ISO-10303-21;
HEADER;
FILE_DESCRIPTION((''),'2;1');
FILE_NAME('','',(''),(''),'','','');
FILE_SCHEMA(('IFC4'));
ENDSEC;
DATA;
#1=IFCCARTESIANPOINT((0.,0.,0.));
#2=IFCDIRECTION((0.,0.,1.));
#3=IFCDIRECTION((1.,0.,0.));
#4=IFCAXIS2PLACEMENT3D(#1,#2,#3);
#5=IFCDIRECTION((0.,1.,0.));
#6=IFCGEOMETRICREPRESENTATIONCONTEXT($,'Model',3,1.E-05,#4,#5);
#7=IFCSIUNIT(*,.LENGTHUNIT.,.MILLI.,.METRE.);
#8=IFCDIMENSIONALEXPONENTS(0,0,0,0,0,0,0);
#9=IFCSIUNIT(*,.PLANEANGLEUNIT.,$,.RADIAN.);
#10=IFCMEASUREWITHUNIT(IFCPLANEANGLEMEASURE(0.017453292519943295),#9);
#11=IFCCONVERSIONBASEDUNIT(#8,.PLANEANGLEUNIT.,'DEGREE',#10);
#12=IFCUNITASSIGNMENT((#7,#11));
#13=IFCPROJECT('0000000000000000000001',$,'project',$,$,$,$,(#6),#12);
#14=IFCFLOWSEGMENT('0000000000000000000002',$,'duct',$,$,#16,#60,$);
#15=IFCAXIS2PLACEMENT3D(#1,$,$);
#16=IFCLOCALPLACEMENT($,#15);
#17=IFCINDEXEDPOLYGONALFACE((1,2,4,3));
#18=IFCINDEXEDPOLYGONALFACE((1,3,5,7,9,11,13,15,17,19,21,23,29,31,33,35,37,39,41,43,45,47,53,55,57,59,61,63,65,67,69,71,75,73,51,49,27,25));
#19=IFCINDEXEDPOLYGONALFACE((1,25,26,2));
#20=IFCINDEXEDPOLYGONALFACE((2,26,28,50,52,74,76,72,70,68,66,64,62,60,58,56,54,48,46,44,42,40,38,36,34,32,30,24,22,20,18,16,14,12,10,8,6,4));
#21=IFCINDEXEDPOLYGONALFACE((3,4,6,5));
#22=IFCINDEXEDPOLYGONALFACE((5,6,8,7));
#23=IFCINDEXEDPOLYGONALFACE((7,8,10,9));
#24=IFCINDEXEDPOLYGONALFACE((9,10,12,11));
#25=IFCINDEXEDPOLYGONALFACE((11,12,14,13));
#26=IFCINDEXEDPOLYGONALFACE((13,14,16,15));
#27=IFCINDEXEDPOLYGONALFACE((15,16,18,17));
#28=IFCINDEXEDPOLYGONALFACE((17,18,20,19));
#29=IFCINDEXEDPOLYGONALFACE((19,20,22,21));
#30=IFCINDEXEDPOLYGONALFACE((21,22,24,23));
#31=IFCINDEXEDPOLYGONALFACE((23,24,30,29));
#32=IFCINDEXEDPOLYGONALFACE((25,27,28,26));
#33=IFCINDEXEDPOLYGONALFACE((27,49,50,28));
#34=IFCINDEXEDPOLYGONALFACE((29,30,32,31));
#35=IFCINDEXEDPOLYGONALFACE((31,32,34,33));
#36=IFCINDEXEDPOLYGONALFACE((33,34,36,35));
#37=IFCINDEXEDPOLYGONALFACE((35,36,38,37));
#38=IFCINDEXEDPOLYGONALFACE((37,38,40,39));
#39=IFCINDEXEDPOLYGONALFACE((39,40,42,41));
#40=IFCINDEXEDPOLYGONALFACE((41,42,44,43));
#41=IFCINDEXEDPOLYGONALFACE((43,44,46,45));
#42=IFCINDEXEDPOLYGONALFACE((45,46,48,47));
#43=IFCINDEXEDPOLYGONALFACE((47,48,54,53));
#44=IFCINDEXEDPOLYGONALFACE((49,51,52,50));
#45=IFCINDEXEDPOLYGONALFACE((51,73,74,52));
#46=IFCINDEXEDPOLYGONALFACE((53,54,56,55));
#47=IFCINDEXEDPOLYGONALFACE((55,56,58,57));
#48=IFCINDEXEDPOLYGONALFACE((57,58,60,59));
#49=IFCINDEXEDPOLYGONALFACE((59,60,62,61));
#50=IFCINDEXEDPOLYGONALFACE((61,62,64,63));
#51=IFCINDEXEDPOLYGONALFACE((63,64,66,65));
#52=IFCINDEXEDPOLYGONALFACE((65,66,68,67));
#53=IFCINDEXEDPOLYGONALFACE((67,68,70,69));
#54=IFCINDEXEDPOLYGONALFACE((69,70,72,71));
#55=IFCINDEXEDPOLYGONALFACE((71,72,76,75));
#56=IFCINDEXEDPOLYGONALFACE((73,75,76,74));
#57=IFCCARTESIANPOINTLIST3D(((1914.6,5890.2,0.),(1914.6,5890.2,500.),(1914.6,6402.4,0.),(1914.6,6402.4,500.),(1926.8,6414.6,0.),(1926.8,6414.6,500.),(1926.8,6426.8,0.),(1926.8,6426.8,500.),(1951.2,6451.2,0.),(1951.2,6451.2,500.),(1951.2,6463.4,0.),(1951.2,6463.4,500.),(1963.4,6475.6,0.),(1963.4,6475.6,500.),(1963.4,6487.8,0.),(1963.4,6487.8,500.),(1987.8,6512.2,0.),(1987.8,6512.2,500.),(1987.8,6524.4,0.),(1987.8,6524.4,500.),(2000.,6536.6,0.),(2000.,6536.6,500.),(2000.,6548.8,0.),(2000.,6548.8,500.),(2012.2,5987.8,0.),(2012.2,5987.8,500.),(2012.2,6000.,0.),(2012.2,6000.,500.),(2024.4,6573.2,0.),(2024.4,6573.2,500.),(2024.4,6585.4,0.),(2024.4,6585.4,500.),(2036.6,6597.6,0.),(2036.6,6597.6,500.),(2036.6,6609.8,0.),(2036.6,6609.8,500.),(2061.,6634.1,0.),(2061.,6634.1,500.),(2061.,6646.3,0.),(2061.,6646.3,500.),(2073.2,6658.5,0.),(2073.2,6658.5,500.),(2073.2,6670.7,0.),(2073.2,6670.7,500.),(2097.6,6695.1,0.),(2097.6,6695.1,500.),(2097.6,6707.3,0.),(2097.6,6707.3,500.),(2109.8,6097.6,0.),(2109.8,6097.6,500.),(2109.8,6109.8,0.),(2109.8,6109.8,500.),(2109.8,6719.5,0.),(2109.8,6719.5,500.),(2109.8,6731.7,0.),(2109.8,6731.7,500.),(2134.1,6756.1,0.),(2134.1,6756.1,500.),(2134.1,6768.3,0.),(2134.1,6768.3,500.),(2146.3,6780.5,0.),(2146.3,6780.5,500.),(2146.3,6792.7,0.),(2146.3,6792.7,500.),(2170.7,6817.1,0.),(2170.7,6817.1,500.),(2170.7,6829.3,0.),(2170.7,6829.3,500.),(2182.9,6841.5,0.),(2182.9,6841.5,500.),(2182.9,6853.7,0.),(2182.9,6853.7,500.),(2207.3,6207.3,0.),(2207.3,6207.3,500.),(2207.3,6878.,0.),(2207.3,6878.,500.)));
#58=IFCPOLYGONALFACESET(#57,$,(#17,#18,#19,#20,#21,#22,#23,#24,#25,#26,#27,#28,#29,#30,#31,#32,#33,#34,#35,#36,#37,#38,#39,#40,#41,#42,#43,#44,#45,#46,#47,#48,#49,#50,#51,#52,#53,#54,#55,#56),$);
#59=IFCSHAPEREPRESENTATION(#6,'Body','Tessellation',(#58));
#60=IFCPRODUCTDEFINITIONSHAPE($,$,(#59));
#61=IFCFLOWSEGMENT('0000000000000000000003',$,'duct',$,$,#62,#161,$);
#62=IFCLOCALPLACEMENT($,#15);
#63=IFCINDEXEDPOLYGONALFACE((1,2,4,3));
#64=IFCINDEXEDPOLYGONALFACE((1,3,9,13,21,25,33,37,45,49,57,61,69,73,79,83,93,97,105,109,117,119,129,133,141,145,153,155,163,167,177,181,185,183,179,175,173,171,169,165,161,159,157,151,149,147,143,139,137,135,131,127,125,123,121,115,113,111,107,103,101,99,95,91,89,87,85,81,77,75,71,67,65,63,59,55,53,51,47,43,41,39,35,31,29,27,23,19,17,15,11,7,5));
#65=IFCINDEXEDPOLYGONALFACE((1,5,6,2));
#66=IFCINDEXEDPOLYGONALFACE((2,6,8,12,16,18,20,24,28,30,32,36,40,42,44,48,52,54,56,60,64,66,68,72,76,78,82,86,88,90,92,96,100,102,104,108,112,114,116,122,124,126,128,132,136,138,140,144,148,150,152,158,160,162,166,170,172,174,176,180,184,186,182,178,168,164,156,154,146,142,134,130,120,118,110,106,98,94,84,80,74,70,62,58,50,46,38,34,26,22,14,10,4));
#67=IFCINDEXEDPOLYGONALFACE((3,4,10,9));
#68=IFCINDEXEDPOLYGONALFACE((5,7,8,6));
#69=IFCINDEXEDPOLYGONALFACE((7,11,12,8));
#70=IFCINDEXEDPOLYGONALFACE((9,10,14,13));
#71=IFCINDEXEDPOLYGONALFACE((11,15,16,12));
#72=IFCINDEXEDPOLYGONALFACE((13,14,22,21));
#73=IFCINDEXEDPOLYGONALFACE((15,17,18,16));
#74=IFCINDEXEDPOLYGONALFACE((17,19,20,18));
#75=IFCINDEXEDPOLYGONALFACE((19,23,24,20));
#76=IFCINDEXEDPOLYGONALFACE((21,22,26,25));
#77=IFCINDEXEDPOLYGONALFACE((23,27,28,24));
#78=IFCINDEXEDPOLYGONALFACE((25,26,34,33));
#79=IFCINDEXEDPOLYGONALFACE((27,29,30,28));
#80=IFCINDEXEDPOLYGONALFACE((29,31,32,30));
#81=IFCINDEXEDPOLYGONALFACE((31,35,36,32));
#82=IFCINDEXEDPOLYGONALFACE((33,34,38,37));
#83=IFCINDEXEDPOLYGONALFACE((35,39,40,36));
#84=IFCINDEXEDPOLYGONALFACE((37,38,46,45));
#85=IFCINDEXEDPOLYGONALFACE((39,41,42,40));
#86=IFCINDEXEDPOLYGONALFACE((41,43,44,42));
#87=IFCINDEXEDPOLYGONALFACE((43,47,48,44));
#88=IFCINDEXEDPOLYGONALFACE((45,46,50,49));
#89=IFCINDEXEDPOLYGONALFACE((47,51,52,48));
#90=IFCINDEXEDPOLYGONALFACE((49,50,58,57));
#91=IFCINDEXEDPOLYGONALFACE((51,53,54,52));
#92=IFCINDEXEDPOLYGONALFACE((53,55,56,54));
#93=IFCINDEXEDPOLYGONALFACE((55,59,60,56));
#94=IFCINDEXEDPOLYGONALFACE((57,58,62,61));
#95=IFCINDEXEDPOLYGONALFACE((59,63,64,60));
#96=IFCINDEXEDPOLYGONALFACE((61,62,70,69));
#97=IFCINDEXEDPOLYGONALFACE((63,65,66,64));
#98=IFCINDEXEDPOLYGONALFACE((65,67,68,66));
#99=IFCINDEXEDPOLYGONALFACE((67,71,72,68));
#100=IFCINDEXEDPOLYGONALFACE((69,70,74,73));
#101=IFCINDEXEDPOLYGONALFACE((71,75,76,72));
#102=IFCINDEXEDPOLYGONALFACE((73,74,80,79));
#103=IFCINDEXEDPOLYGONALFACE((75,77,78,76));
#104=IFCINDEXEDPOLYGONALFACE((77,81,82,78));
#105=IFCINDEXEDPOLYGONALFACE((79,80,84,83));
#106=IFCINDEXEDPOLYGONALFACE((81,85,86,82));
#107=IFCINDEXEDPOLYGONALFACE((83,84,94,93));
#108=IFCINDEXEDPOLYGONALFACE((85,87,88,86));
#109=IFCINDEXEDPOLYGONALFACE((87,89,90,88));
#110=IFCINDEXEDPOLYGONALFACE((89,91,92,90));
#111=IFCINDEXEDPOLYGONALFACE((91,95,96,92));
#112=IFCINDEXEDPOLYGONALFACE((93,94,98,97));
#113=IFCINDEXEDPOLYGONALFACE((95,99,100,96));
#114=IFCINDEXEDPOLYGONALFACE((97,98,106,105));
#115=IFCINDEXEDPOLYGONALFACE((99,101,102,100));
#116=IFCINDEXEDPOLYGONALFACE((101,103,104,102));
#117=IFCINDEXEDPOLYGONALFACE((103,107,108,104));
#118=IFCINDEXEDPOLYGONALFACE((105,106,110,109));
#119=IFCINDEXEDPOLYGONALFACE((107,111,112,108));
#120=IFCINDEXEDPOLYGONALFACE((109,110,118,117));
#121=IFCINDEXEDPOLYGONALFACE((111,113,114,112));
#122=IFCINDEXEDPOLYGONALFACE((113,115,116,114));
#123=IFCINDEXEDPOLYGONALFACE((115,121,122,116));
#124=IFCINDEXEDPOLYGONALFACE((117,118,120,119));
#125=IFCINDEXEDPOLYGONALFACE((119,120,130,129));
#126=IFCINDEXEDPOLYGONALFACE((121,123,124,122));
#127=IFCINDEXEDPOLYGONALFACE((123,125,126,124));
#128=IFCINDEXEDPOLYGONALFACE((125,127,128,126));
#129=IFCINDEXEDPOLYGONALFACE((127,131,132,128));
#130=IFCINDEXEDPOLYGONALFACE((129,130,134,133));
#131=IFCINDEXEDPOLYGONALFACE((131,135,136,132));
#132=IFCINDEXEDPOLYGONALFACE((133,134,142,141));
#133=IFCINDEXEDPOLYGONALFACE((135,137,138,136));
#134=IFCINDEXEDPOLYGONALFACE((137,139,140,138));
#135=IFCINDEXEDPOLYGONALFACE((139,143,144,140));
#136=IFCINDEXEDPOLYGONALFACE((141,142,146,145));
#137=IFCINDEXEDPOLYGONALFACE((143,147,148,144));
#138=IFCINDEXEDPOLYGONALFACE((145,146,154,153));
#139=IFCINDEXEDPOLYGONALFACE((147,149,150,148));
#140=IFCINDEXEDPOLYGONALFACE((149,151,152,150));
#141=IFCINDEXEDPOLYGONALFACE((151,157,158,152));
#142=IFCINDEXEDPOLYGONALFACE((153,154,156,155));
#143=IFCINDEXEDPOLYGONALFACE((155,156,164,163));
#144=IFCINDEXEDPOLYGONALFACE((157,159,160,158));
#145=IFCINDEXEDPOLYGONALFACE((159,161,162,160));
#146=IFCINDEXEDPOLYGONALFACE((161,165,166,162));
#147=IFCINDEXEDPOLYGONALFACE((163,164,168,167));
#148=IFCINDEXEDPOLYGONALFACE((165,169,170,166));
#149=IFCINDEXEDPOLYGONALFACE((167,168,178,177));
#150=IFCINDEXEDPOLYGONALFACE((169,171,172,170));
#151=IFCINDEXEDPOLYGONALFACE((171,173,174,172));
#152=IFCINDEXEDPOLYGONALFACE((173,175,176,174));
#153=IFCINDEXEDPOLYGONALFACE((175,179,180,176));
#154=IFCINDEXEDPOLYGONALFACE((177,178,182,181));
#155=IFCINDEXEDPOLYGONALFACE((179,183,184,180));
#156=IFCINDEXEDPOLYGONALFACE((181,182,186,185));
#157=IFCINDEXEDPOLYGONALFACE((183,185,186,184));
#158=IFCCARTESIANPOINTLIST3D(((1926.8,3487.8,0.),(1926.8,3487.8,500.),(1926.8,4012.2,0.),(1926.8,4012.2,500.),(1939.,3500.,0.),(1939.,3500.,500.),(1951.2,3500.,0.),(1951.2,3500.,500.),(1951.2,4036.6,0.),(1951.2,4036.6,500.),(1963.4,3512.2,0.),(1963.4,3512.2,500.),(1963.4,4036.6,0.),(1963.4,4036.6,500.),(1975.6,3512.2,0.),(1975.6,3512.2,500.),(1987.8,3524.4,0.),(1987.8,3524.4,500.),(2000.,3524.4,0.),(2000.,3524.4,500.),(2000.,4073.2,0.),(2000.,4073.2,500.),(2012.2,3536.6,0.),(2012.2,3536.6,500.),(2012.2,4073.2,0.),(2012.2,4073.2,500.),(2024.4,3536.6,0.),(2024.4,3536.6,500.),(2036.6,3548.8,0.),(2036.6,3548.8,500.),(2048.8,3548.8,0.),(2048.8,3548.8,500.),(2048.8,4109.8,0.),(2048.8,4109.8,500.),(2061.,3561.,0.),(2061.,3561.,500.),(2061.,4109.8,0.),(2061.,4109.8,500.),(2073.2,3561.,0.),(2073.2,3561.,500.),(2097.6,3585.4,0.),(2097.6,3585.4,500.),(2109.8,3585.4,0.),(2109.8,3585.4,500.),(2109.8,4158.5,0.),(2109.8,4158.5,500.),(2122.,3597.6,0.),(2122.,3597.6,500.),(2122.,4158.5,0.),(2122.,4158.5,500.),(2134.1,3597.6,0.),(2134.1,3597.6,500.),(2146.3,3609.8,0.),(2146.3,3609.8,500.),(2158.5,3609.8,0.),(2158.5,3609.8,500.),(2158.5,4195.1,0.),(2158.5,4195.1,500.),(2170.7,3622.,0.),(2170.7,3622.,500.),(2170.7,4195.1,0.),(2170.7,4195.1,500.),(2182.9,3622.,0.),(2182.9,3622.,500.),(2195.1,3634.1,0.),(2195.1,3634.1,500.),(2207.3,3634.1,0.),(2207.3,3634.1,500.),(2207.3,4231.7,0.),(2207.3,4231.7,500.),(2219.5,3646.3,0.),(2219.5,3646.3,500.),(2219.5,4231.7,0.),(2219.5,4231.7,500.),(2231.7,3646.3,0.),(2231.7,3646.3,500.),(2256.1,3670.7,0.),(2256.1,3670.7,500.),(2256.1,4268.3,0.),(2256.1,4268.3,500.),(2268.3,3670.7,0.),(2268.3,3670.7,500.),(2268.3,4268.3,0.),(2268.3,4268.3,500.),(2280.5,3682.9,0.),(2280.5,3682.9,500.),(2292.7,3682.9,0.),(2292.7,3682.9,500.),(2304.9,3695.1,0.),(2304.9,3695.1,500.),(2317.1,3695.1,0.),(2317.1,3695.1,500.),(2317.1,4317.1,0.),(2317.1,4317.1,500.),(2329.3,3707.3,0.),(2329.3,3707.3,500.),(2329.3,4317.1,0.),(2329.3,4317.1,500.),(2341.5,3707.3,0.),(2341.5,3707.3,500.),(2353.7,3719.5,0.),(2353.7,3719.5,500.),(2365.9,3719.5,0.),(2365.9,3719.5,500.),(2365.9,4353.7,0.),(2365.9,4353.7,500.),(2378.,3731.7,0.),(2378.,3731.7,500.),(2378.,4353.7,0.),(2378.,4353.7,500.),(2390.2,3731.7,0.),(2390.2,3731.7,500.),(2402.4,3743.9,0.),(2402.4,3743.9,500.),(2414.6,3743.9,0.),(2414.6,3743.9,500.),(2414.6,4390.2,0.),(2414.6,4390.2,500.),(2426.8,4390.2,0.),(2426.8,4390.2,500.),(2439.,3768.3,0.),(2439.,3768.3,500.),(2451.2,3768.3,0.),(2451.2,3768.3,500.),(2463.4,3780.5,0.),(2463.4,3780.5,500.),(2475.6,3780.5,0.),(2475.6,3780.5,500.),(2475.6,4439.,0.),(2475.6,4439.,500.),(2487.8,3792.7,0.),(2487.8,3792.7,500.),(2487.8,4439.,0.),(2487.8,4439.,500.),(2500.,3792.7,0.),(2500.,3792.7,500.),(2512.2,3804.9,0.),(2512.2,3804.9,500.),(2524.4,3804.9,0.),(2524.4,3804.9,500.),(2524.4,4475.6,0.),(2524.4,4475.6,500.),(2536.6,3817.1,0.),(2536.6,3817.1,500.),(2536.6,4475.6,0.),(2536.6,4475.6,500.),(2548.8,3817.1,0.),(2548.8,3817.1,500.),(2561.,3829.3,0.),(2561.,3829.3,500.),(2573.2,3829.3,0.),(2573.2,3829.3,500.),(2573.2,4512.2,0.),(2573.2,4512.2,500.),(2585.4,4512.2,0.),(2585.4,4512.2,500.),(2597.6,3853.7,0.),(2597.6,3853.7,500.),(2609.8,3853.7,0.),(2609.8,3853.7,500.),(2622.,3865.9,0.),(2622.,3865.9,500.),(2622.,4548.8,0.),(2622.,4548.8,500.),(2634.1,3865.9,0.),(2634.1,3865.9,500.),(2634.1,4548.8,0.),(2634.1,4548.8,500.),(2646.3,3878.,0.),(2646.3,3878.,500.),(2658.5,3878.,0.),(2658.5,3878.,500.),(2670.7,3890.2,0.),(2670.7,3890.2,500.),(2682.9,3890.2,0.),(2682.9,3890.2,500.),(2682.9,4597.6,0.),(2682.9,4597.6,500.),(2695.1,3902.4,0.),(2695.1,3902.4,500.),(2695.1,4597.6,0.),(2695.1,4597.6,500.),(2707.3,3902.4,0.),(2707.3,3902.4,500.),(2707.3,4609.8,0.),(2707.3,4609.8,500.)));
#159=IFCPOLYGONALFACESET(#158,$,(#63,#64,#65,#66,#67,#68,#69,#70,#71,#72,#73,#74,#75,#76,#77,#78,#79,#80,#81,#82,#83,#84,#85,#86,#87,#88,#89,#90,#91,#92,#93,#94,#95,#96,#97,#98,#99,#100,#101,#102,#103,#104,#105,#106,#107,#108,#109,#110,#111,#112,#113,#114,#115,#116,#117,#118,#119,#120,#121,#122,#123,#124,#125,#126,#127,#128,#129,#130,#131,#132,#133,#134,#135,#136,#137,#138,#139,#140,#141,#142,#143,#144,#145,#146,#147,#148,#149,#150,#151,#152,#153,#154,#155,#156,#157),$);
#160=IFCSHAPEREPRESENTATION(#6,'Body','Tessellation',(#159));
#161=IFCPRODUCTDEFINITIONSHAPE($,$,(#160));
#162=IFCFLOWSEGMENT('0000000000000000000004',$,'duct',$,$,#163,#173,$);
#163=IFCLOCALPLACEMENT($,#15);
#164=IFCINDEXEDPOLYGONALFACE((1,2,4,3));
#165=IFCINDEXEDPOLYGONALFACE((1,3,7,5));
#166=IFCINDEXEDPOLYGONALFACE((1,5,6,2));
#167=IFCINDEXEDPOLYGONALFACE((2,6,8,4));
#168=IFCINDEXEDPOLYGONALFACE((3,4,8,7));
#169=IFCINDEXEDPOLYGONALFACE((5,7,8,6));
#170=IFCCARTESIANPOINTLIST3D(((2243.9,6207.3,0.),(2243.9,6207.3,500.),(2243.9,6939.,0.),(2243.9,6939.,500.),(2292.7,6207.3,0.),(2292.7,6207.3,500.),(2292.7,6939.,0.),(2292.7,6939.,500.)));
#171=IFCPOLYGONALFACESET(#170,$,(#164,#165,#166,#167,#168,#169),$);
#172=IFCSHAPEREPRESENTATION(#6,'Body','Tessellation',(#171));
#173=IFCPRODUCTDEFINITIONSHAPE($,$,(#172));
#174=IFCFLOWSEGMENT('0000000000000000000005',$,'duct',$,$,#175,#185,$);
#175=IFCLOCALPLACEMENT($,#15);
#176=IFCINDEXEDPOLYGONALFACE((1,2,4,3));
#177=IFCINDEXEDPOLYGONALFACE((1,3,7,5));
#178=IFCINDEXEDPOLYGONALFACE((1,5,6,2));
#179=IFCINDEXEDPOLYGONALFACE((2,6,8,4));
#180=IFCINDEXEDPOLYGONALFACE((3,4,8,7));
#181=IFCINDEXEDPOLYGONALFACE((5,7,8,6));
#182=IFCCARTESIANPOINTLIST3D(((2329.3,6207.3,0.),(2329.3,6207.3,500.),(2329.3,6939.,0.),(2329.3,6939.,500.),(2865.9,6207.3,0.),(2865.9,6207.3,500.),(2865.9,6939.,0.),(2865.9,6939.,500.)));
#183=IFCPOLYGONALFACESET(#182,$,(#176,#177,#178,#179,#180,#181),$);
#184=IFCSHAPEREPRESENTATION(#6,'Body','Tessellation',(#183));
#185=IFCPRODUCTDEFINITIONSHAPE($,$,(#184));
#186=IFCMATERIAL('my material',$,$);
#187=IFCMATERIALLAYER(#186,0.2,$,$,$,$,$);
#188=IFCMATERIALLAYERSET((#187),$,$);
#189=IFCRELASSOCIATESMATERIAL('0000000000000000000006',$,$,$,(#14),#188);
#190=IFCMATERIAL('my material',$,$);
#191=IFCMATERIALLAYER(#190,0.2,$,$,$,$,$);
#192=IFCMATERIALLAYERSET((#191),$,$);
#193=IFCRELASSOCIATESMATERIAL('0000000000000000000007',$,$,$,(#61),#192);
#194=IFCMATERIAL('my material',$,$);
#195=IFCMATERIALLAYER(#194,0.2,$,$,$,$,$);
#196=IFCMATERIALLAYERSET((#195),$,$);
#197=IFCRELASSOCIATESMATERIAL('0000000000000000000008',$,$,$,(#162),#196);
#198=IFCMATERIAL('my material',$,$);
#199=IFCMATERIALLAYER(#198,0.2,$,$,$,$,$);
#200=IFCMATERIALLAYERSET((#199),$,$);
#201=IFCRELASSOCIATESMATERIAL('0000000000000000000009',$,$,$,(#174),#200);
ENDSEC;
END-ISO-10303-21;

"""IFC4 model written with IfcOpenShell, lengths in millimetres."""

from ifc_helpers import new_model, entity, si_unit, converted_unit, direction, origin_with_axes, place, context, project, polyline, outline, extrude, material, layer, layer_set, layer_usage, element, save


model = new_model("IFC4")

# Units and contexts
model_context = context("Model", 3, precision=1e-05, world=origin_with_axes(), true_north=direction((0.0, 1.0, 0.0)))
ifc_project = project(units=[si_unit("LENGTHUNIT", "METRE", prefix="MILLI"), converted_unit("PLANEANGLEUNIT", "DEGREE", entity("IfcPlaneAngleMeasure", 0.017453292519943295), si_unit("PLANEANGLEUNIT", "RADIAN"), dimensions=[0, 0, 0, 0, 0, 0, 0])], contexts=[model_context])

# Flow segments
ifc_material_1 = material(Name="my material")
ifc_layer_1 = layer(ifc_material_1, 0.2)
ifc_layer_set_1 = layer_set([ifc_layer_1])
ifc_layer_usage_1 = layer_usage(ifc_layer_set_1, "AXIS2", "POSITIVE", -0.1)
flow_segment_1_placement = place(None, origin_with_axes())
element("IfcFlowSegment", 1, at=flow_segment_1_placement, material=ifc_layer_usage_1, Name="duct", context=model_context, shape_type="SweptSolid", body=[
    extrude(outline(polyline([(1914.6, 5878.0), (1914.6, 5890.2), (2012.2, 5987.8), (2012.2, 6000.0), (2109.8, 6097.6), (2109.8, 6109.8), (2207.3, 6207.3), (2207.3, 6890.2), (2207.3, 6878.0), (2182.9, 6853.7), (2182.9, 6841.5), (2170.7, 6829.3), (2170.7, 6817.1), (2146.3, 6792.7), (2146.3, 6780.5), (2134.1, 6768.3), (2134.1, 6756.1), (2109.8, 6731.7), (2109.8, 6719.5), (2097.6, 6707.3), (2097.6, 6695.1), (2073.2, 6670.7), (2073.2, 6658.5), (2061.0, 6646.3), (2061.0, 6634.1), (2036.6, 6609.8), (2036.6, 6597.6), (2024.4, 6585.4), (2024.4, 6573.2), (2000.0, 6548.8), (2000.0, 6536.6), (1987.8, 6524.4), (1987.8, 6512.2), (1963.4, 6487.8), (1963.4, 6475.6), (1951.2, 6463.4), (1951.2, 6451.2), (1926.8, 6426.8), (1926.8, 6414.6), (1914.6, 6402.4), (1914.6, 5878.0)])), origin_with_axes(), (0.0, 0.0, 1.0), 500.0),
])
ifc_material_2 = material(Name="my material")
ifc_layer_2 = layer(ifc_material_2, 0.2)
ifc_layer_set_2 = layer_set([ifc_layer_2])
ifc_layer_usage_2 = layer_usage(ifc_layer_set_2, "AXIS2", "POSITIVE", -0.1)
flow_segment_2_placement = place(None, origin_with_axes())
element("IfcFlowSegment", 2, at=flow_segment_2_placement, material=ifc_layer_usage_2, Name="duct", context=model_context, shape_type="SweptSolid", body=[
    extrude(outline(polyline([(1926.8, 3487.8), (1939.0, 3500.0), (1951.2, 3500.0), (1963.4, 3512.2), (1975.6, 3512.2), (1987.8, 3524.4), (2000.0, 3524.4), (2012.2, 3536.6), (2024.4, 3536.6), (2036.6, 3548.8), (2048.8, 3548.8), (2061.0, 3561.0), (2073.2, 3561.0), (2097.6, 3585.4), (2109.8, 3585.4), (2122.0, 3597.6), (2134.1, 3597.6), (2146.3, 3609.8), (2158.5, 3609.8), (2170.7, 3622.0), (2182.9, 3622.0), (2195.1, 3634.1), (2207.3, 3634.1), (2219.5, 3646.3), (2231.7, 3646.3), (2256.1, 3670.7), (2268.3, 3670.7), (2280.5, 3682.9), (2292.7, 3682.9), (2304.9, 3695.1), (2317.1, 3695.1), (2329.3, 3707.3), (2341.5, 3707.3), (2353.7, 3719.5), (2365.9, 3719.5), (2378.0, 3731.7), (2390.2, 3731.7), (2402.4, 3743.9), (2414.6, 3743.9), (2439.0, 3768.3), (2451.2, 3768.3), (2463.4, 3780.5), (2475.6, 3780.5), (2487.8, 3792.7), (2500.0, 3792.7), (2512.2, 3804.9), (2524.4, 3804.9), (2536.6, 3817.1), (2548.8, 3817.1), (2561.0, 3829.3), (2573.2, 3829.3), (2597.6, 3853.7), (2609.8, 3853.7), (2622.0, 3865.9), (2634.1, 3865.9), (2646.3, 3878.0), (2658.5, 3878.0), (2670.7, 3890.2), (2682.9, 3890.2), (2695.1, 3902.4), (2707.3, 3902.4), (2707.3, 4609.8), (2695.1, 4597.6), (2682.9, 4597.6), (2634.1, 4548.8), (2622.0, 4548.8), (2585.4, 4512.2), (2573.2, 4512.2), (2536.6, 4475.6), (2524.4, 4475.6), (2487.8, 4439.0), (2475.6, 4439.0), (2426.8, 4390.2), (2414.6, 4390.2), (2378.0, 4353.7), (2365.9, 4353.7), (2329.3, 4317.1), (2317.1, 4317.1), (2268.3, 4268.3), (2256.1, 4268.3), (2219.5, 4231.7), (2207.3, 4231.7), (2170.7, 4195.1), (2158.5, 4195.1), (2122.0, 4158.5), (2109.8, 4158.5), (2061.0, 4109.8), (2048.8, 4109.8), (2012.2, 4073.2), (2000.0, 4073.2), (1963.4, 4036.6), (1951.2, 4036.6), (1926.8, 4012.2), (1926.8, 3487.8)])), origin_with_axes(), (0.0, 0.0, 1.0), 500.0),
])
ifc_material_3 = material(Name="my material")
ifc_layer_3 = layer(ifc_material_3, 0.2)
ifc_layer_set_3 = layer_set([ifc_layer_3])
ifc_layer_usage_3 = layer_usage(ifc_layer_set_3, "AXIS2", "POSITIVE", -0.1)
flow_segment_3_placement = place(None, origin_with_axes())
element("IfcFlowSegment", 3, at=flow_segment_3_placement, material=ifc_layer_usage_3, Name="duct", context=model_context, shape_type="SweptSolid", body=[
    extrude(outline(polyline([(2243.9, 6207.3), (2292.7, 6207.3), (2292.7, 6939.0), (2243.9, 6939.0), (2243.9, 6207.3)])), origin_with_axes(), (0.0, 0.0, 1.0), 500.0),
])
ifc_material_4 = material(Name="my material")
ifc_layer_4 = layer(ifc_material_4, 0.2)
ifc_layer_set_4 = layer_set([ifc_layer_4])
ifc_layer_usage_4 = layer_usage(ifc_layer_set_4, "AXIS2", "POSITIVE", -0.1)
flow_segment_4_placement = place(None, origin_with_axes())
element("IfcFlowSegment", 4, at=flow_segment_4_placement, material=ifc_layer_usage_4, Name="duct", context=model_context, shape_type="SweptSolid", body=[
    extrude(outline(polyline([(2329.3, 6207.3), (2865.9, 6207.3), (2865.9, 6939.0), (2329.3, 6939.0), (2329.3, 6207.3)])), origin_with_axes(), (0.0, 0.0, 1.0), 500.0),
])

save(model, "model.ifc")
